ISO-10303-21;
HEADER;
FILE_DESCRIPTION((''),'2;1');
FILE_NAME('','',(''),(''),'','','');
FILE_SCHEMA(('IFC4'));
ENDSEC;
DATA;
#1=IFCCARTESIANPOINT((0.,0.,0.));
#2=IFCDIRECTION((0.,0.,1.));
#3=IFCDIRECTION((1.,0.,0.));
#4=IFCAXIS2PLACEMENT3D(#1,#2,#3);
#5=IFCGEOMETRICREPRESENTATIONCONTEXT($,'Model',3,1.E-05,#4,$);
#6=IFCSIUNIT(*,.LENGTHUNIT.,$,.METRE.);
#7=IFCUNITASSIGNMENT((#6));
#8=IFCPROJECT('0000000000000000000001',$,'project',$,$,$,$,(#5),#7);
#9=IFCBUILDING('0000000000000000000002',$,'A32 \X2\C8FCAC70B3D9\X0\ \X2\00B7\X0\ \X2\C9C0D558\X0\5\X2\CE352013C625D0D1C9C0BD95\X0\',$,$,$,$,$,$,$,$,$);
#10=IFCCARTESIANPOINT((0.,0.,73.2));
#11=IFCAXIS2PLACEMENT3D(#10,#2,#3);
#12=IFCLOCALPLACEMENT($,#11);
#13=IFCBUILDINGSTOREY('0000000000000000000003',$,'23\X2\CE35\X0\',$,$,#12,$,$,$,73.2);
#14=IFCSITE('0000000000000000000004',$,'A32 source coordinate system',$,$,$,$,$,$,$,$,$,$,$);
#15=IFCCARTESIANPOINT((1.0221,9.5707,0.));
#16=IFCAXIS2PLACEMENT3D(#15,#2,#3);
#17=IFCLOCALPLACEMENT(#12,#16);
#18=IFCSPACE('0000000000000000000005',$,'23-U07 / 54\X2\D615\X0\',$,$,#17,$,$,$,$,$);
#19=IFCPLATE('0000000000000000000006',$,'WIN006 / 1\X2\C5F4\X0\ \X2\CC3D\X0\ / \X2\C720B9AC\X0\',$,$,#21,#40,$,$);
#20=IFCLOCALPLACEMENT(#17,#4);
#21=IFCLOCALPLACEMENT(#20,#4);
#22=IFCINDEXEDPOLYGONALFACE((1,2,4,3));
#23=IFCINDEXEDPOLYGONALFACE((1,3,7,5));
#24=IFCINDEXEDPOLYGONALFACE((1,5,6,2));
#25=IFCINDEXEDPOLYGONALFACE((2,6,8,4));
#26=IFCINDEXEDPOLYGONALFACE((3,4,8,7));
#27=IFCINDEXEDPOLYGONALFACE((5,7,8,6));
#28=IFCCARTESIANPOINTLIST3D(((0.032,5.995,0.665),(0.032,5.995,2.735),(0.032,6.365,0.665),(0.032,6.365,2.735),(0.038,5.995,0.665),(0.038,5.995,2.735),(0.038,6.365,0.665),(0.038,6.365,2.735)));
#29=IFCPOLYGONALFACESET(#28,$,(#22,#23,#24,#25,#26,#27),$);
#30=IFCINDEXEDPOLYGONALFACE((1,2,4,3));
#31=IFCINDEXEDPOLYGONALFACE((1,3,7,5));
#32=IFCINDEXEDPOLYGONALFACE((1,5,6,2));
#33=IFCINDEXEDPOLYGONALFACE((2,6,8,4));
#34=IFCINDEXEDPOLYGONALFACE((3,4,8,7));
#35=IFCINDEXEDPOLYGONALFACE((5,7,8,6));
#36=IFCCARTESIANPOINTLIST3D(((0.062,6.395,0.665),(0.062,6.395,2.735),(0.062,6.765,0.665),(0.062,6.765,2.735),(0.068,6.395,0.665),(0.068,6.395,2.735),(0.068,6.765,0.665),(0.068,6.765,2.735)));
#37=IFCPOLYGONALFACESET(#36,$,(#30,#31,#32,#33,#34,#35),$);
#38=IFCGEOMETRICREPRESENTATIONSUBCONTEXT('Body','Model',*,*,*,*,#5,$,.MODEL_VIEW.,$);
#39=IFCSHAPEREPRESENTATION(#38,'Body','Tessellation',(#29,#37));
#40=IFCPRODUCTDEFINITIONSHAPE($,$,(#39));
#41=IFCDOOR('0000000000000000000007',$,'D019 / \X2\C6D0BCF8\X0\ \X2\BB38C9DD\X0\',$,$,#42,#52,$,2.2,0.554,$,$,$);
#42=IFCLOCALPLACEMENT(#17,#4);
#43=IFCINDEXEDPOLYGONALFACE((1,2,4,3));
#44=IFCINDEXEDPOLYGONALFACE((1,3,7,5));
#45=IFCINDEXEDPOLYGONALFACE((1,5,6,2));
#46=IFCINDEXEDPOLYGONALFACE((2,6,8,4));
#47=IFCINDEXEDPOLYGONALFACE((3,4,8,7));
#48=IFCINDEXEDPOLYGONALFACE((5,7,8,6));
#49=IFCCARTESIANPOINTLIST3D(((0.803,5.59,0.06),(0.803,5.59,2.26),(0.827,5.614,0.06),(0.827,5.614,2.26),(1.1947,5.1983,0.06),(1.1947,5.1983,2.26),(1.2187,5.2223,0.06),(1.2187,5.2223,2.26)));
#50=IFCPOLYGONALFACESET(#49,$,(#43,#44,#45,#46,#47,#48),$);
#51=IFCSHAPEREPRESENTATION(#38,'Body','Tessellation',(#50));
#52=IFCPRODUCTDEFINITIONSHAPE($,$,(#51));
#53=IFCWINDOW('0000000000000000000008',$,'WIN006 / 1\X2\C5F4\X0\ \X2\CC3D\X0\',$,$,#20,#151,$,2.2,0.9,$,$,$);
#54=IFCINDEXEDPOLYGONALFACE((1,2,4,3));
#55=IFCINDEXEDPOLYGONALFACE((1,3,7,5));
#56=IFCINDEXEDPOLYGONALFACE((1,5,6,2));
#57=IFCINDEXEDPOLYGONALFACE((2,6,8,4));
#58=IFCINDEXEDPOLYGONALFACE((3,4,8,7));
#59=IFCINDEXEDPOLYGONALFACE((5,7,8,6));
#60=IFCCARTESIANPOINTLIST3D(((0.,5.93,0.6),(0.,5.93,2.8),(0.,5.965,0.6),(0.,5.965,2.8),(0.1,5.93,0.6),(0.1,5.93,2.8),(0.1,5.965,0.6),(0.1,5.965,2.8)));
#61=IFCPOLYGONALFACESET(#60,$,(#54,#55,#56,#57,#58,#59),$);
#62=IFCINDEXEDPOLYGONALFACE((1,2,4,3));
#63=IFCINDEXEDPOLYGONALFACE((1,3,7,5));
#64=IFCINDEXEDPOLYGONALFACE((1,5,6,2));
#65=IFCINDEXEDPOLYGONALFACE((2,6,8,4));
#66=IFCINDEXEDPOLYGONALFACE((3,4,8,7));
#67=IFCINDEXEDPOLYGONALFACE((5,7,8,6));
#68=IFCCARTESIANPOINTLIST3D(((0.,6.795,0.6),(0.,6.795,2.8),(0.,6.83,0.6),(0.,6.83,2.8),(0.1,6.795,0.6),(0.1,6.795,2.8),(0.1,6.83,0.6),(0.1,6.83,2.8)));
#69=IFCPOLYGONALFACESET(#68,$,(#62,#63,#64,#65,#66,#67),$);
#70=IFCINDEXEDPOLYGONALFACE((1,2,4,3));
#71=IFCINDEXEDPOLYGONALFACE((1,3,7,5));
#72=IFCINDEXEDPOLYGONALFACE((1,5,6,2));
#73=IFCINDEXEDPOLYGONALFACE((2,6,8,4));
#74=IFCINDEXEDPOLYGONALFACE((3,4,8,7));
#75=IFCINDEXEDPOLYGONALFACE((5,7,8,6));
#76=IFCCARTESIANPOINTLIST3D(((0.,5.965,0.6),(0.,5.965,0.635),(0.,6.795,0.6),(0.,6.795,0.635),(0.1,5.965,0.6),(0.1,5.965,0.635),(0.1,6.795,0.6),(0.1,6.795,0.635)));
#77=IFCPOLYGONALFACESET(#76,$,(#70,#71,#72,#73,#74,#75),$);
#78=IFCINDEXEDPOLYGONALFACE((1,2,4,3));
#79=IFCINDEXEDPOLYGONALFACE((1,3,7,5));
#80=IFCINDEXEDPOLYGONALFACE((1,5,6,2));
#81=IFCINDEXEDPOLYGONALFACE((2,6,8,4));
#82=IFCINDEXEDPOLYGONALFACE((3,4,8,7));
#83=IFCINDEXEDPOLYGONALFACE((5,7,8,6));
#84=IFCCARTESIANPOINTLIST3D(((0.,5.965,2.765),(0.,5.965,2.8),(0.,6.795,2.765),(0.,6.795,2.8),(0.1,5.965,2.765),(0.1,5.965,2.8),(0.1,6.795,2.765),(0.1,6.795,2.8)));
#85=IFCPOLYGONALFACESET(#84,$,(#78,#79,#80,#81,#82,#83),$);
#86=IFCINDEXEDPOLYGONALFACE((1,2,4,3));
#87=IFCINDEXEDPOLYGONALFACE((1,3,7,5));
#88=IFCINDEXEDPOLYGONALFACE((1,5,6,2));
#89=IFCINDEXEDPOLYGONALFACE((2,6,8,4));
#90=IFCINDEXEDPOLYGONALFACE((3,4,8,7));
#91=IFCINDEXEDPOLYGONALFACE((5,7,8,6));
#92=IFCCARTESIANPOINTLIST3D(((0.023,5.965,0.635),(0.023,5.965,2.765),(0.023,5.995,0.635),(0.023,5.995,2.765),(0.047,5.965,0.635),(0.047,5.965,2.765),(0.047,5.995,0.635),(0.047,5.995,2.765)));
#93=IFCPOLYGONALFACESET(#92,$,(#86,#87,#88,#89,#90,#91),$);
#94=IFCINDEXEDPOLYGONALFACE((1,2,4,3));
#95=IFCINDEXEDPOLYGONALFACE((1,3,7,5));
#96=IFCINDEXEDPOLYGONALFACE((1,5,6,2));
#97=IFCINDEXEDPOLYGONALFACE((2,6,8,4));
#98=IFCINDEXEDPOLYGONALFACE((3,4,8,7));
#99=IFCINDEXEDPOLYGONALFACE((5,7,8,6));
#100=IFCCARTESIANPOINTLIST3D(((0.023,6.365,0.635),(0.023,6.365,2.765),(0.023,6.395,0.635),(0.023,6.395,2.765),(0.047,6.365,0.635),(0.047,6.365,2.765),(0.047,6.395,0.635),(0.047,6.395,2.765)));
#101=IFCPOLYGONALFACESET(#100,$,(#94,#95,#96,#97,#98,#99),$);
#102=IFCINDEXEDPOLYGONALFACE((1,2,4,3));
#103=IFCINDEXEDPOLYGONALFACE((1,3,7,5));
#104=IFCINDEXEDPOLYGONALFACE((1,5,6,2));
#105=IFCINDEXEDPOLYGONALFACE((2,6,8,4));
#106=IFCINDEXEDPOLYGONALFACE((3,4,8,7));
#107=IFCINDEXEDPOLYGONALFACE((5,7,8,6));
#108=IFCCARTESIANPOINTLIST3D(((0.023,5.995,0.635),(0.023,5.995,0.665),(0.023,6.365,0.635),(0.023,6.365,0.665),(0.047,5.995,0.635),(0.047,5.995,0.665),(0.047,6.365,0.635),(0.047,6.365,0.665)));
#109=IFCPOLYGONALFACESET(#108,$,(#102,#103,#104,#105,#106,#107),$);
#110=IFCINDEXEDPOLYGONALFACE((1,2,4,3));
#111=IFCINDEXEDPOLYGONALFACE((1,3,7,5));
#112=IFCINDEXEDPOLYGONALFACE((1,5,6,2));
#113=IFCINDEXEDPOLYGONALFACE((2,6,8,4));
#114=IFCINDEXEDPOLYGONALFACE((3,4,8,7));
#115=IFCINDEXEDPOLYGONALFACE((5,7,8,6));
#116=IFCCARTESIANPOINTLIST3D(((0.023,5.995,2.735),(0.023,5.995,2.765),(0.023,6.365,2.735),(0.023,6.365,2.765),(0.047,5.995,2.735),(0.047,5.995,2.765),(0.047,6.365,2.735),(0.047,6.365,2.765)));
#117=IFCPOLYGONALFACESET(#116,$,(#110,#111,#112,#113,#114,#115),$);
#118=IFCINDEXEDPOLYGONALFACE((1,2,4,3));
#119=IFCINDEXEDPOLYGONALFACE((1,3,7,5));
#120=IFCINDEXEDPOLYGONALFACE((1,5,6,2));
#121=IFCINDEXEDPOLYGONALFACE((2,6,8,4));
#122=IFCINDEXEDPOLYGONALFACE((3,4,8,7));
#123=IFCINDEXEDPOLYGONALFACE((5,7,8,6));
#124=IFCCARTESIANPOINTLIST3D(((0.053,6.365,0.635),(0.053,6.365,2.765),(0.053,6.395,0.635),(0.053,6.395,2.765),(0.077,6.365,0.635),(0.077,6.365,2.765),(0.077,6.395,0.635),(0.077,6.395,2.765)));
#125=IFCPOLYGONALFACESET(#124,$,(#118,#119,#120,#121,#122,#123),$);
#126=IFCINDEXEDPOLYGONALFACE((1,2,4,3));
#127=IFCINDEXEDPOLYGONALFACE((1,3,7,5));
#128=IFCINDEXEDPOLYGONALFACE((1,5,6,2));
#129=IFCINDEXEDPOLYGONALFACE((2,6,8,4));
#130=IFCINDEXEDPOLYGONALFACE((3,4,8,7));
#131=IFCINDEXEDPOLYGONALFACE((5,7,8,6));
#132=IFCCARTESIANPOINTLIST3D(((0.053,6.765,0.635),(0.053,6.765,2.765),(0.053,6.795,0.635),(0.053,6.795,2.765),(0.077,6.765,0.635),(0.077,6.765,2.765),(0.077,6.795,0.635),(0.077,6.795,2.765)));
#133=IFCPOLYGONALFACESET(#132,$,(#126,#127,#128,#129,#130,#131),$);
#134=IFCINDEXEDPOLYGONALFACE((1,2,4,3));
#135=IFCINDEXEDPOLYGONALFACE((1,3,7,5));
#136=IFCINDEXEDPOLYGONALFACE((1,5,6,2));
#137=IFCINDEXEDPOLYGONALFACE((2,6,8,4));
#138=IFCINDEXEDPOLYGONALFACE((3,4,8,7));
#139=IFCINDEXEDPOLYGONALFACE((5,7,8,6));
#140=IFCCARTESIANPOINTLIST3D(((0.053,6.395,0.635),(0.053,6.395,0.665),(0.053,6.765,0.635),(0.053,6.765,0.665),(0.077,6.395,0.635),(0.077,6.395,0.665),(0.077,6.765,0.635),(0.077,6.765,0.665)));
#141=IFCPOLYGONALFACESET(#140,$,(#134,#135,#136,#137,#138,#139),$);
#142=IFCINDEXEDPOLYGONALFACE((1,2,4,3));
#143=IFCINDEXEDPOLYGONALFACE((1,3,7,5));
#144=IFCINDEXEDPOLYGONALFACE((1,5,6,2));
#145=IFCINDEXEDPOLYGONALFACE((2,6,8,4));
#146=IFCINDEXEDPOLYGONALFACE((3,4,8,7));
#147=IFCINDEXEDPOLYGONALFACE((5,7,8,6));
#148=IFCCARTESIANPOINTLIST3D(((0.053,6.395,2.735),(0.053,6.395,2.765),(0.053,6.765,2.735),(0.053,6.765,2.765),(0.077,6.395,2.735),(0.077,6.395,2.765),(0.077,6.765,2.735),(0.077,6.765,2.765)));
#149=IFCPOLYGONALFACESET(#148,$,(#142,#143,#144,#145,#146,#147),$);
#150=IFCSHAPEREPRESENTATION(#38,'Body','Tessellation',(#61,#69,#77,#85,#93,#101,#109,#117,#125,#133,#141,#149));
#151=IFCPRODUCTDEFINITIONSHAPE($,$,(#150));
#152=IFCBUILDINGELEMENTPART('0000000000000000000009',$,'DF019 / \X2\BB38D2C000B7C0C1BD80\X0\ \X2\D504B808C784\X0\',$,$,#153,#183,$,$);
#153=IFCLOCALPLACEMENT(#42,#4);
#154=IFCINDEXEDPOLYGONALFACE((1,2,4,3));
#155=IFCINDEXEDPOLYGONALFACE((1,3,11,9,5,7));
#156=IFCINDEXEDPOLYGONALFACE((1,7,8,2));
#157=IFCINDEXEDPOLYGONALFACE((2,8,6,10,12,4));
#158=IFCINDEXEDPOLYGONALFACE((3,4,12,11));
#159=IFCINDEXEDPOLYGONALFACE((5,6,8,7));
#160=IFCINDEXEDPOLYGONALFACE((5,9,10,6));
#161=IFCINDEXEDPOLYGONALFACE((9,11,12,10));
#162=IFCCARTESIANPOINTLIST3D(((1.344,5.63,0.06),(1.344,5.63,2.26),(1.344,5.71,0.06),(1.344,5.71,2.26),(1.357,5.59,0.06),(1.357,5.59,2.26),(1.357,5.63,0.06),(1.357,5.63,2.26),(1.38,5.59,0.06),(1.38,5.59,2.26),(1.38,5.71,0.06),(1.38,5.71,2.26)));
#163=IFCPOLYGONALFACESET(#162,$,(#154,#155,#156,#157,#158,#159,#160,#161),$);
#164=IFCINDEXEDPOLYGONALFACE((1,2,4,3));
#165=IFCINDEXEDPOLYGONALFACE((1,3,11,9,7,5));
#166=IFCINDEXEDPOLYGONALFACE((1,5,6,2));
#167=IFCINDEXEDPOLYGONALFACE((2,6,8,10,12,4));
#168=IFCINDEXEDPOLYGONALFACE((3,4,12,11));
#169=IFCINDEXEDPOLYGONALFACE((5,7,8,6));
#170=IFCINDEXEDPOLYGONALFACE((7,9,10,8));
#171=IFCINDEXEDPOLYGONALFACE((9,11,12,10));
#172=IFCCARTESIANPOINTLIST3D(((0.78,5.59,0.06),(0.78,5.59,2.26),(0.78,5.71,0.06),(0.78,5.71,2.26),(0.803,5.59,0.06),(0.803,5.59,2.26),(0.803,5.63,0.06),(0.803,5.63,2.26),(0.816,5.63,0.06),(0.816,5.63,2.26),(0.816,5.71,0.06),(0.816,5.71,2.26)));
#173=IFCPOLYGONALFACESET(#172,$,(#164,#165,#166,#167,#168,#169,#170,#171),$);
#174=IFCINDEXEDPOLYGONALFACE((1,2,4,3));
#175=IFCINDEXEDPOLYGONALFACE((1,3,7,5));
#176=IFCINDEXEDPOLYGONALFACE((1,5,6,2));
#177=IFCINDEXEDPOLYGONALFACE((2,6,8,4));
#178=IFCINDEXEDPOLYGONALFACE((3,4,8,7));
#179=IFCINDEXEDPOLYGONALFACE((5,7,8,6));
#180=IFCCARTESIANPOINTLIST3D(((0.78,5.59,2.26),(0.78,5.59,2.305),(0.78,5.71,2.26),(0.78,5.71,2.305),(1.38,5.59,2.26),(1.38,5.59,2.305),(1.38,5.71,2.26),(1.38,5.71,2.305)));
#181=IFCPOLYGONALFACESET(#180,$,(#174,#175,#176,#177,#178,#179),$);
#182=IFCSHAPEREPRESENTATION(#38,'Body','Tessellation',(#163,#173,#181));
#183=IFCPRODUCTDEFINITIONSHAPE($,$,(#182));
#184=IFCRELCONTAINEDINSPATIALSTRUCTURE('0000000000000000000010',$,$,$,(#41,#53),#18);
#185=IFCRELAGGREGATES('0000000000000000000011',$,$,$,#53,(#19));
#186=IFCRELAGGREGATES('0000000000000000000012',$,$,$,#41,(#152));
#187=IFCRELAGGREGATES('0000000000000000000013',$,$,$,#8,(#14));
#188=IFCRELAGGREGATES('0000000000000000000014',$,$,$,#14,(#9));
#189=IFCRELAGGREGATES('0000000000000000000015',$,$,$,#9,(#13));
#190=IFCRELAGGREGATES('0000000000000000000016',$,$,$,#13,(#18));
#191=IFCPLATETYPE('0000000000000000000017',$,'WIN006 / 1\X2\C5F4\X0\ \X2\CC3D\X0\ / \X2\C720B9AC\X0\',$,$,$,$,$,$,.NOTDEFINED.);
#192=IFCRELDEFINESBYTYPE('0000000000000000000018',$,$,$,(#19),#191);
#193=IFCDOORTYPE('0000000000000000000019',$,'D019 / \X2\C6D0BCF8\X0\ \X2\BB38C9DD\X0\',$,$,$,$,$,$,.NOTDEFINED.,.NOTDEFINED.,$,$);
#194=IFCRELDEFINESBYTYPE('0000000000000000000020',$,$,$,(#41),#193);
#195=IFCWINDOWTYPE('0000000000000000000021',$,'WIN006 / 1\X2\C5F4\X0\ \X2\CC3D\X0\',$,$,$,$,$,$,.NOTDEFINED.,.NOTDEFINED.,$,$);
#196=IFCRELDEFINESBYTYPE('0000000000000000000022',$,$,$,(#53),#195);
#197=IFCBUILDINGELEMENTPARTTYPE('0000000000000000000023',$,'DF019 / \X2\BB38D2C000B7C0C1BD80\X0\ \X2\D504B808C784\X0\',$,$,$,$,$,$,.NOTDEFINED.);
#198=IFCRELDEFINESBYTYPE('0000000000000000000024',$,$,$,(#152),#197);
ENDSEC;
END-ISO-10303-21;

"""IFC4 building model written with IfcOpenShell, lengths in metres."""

from ifc_helpers import new_model, si_unit, frame, origin, origin_with_axes, place, context, subcontext, project, spatial, polyline, outline, extrude, source, transform, mapped, type_object, type_shapes, element, aggregate, save


model = new_model("IFC4")

# Units and contexts
model_context = context("Model", 3, precision=1e-05, world=origin_with_axes())
body_context = subcontext(model_context, "Body", "Model", "MODEL_VIEW")
ifc_project = project(units=[si_unit("LENGTHUNIT", "METRE")], contexts=[model_context])

# Plate
storey_placement = place(None, frame((0.0, 0.0, 73.2), z_axis=(0.0, 0.0, 1.0), x_axis=(1.0, 0.0, 0.0)))
space_placement = place(storey_placement, frame((1.0221, 9.5707, 0.0), z_axis=(0.0, 0.0, 1.0), x_axis=(1.0, 0.0, 0.0)))
plate_type_1 = type_object("IfcPlateType", Name="WIN006 / 1열 창 / 유리", PredefinedType="NOTDEFINED")
shared_shape_1 = source(origin(), body_context, "Body", "SweptSolid", [
    extrude(outline(polyline([(0.032, 5.995), (0.032, 6.365), (0.038, 6.365), (0.038, 5.995), (0.032, 5.995)])), frame((0.0, 0.0, 0.665)), (0.0, 0.0, 1.0), 2.07),
    extrude(outline(polyline([(0.062, 6.395), (0.062, 6.765), (0.068, 6.765), (0.068, 6.395), (0.062, 6.395)])), frame((0.0, 0.0, 0.665)), (0.0, 0.0, 1.0), 2.07),
])
type_shapes(plate_type_1, [shared_shape_1])
window_1_placement = place(space_placement, origin_with_axes())
plate_1_placement = place(window_1_placement, origin_with_axes())
plate_1 = element("IfcPlate", 1, at=plate_1_placement, type_object=plate_type_1, Name="WIN006 / 1열 창 / 유리", context=body_context, shape_type="MappedRepresentation", body=[
    mapped(shared_shape_1, transform((0.0, 0.0, 0.0), scale=1.0)),
])

# Site, building, storey, space
site = spatial("IfcSite", under=ifc_project, Name="A32 source coordinate system")
building = spatial("IfcBuilding", under=site, Name="A32 주거동 · 지하5층–옥탑지붕")
storey = spatial("IfcBuildingStorey", under=building, at=storey_placement, Name="23층", Elevation=73.2)
space = spatial("IfcSpace", under=storey, at=space_placement, Name="23-U07 / 54형")

# Door
door_type_1 = type_object("IfcDoorType", Name="D019 / 원본 문짝", OperationType="NOTDEFINED", PredefinedType="NOTDEFINED")
shared_shape_2 = source(origin(), body_context, "Body", "SweptSolid", [
    extrude(outline(polyline([(1.2187, 5.2223), (1.1947, 5.1983), (0.803, 5.59), (0.827, 5.614), (1.2187, 5.2223)])), frame((0.0, 0.0, 0.06)), (0.0, 0.0, 1.0), 2.2),
])
type_shapes(door_type_1, [shared_shape_2])
door_1_placement = place(space_placement, origin_with_axes())
door_1 = element("IfcDoor", 2, at=door_1_placement, inside=space, type_object=door_type_1, Name="D019 / 원본 문짝", OverallHeight=2.2, OverallWidth=0.554, context=body_context, shape_type="MappedRepresentation", body=[
    mapped(shared_shape_2, transform((0.0, 0.0, 0.0), scale=1.0)),
])

# Window
window_type_1 = type_object("IfcWindowType", Name="WIN006 / 1열 창", PartitioningType="NOTDEFINED", PredefinedType="NOTDEFINED")
shared_shape_3 = source(origin(), body_context, "Body", "SweptSolid", [
    extrude(outline(polyline([(0.0, 5.93), (0.0, 5.965), (0.1, 5.965), (0.1, 5.93), (0.0, 5.93)])), frame((0.0, 0.0, 0.6)), (0.0, 0.0, 1.0), 2.2),
    extrude(outline(polyline([(0.0, 6.795), (0.0, 6.83), (0.1, 6.83), (0.1, 6.795), (0.0, 6.795)])), frame((0.0, 0.0, 0.6)), (0.0, 0.0, 1.0), 2.2),
    extrude(outline(polyline([(0.0, 5.965), (0.0, 6.795), (0.1, 6.795), (0.1, 5.965), (0.0, 5.965)])), frame((0.0, 0.0, 0.6)), (0.0, 0.0, 1.0), 0.035),
    extrude(outline(polyline([(0.0, 5.965), (0.0, 6.795), (0.1, 6.795), (0.1, 5.965), (0.0, 5.965)])), frame((0.0, 0.0, 2.765)), (0.0, 0.0, 1.0), 0.035),
    extrude(outline(polyline([(0.023, 5.965), (0.023, 5.995), (0.047, 5.995), (0.047, 5.965), (0.023, 5.965)])), frame((0.0, 0.0, 0.635)), (0.0, 0.0, 1.0), 2.13),
    extrude(outline(polyline([(0.023, 6.365), (0.023, 6.395), (0.047, 6.395), (0.047, 6.365), (0.023, 6.365)])), frame((0.0, 0.0, 0.635)), (0.0, 0.0, 1.0), 2.13),
    extrude(outline(polyline([(0.023, 5.995), (0.023, 6.365), (0.047, 6.365), (0.047, 5.995), (0.023, 5.995)])), frame((0.0, 0.0, 0.635)), (0.0, 0.0, 1.0), 0.03),
    extrude(outline(polyline([(0.023, 5.995), (0.023, 6.365), (0.047, 6.365), (0.047, 5.995), (0.023, 5.995)])), frame((0.0, 0.0, 2.735)), (0.0, 0.0, 1.0), 0.03),
    extrude(outline(polyline([(0.053, 6.365), (0.053, 6.395), (0.077, 6.395), (0.077, 6.365), (0.053, 6.365)])), frame((0.0, 0.0, 0.635)), (0.0, 0.0, 1.0), 2.13),
    extrude(outline(polyline([(0.053, 6.765), (0.053, 6.795), (0.077, 6.795), (0.077, 6.765), (0.053, 6.765)])), frame((0.0, 0.0, 0.635)), (0.0, 0.0, 1.0), 2.13),
    extrude(outline(polyline([(0.053, 6.395), (0.053, 6.765), (0.077, 6.765), (0.077, 6.395), (0.053, 6.395)])), frame((0.0, 0.0, 0.635)), (0.0, 0.0, 1.0), 0.03),
    extrude(outline(polyline([(0.053, 6.395), (0.053, 6.765), (0.077, 6.765), (0.077, 6.395), (0.053, 6.395)])), frame((0.0, 0.0, 2.735)), (0.0, 0.0, 1.0), 0.03),
])
type_shapes(window_type_1, [shared_shape_3])
window_1 = element("IfcWindow", 3, at=window_1_placement, inside=space, type_object=window_type_1, Name="WIN006 / 1열 창", OverallHeight=2.2, OverallWidth=0.9, context=body_context, shape_type="MappedRepresentation", body=[
    mapped(shared_shape_3, transform((0.0, 0.0, 0.0), scale=1.0)),
])
aggregate(window_1, [plate_1])

# Building element part
building_element_part_type_1 = type_object("IfcBuildingElementPartType", Name="DF019 / 문틀·상부 프레임", PredefinedType="NOTDEFINED")
shared_shape_4 = source(origin(), body_context, "Body", "SweptSolid", [
    extrude(outline(polyline([(1.38, 5.59), (1.357, 5.59), (1.357, 5.63), (1.344, 5.63), (1.344, 5.71), (1.38, 5.71), (1.38, 5.59)])), frame((0.0, 0.0, 0.06)), (0.0, 0.0, 1.0), 2.2),
    extrude(outline(polyline([(0.816, 5.71), (0.816, 5.63), (0.803, 5.63), (0.803, 5.59), (0.78, 5.59), (0.78, 5.71), (0.816, 5.71)])), frame((0.0, 0.0, 0.06)), (0.0, 0.0, 1.0), 2.2),
    extrude(outline(polyline([(0.78, 5.59), (0.78, 5.71), (1.38, 5.71), (1.38, 5.59), (0.78, 5.59)])), frame((0.0, 0.0, 2.26)), (0.0, 0.0, 1.0), 0.045),
])
type_shapes(building_element_part_type_1, [shared_shape_4])
building_element_part_1_placement = place(door_1_placement, origin_with_axes())
building_element_part_1 = element("IfcBuildingElementPart", 4, at=building_element_part_1_placement, type_object=building_element_part_type_1, Name="DF019 / 문틀·상부 프레임", context=body_context, shape_type="MappedRepresentation", body=[
    mapped(shared_shape_4, transform((0.0, 0.0, 0.0), scale=1.0)),
])
aggregate(door_1, [building_element_part_1])

save(model, "model.ifc")
